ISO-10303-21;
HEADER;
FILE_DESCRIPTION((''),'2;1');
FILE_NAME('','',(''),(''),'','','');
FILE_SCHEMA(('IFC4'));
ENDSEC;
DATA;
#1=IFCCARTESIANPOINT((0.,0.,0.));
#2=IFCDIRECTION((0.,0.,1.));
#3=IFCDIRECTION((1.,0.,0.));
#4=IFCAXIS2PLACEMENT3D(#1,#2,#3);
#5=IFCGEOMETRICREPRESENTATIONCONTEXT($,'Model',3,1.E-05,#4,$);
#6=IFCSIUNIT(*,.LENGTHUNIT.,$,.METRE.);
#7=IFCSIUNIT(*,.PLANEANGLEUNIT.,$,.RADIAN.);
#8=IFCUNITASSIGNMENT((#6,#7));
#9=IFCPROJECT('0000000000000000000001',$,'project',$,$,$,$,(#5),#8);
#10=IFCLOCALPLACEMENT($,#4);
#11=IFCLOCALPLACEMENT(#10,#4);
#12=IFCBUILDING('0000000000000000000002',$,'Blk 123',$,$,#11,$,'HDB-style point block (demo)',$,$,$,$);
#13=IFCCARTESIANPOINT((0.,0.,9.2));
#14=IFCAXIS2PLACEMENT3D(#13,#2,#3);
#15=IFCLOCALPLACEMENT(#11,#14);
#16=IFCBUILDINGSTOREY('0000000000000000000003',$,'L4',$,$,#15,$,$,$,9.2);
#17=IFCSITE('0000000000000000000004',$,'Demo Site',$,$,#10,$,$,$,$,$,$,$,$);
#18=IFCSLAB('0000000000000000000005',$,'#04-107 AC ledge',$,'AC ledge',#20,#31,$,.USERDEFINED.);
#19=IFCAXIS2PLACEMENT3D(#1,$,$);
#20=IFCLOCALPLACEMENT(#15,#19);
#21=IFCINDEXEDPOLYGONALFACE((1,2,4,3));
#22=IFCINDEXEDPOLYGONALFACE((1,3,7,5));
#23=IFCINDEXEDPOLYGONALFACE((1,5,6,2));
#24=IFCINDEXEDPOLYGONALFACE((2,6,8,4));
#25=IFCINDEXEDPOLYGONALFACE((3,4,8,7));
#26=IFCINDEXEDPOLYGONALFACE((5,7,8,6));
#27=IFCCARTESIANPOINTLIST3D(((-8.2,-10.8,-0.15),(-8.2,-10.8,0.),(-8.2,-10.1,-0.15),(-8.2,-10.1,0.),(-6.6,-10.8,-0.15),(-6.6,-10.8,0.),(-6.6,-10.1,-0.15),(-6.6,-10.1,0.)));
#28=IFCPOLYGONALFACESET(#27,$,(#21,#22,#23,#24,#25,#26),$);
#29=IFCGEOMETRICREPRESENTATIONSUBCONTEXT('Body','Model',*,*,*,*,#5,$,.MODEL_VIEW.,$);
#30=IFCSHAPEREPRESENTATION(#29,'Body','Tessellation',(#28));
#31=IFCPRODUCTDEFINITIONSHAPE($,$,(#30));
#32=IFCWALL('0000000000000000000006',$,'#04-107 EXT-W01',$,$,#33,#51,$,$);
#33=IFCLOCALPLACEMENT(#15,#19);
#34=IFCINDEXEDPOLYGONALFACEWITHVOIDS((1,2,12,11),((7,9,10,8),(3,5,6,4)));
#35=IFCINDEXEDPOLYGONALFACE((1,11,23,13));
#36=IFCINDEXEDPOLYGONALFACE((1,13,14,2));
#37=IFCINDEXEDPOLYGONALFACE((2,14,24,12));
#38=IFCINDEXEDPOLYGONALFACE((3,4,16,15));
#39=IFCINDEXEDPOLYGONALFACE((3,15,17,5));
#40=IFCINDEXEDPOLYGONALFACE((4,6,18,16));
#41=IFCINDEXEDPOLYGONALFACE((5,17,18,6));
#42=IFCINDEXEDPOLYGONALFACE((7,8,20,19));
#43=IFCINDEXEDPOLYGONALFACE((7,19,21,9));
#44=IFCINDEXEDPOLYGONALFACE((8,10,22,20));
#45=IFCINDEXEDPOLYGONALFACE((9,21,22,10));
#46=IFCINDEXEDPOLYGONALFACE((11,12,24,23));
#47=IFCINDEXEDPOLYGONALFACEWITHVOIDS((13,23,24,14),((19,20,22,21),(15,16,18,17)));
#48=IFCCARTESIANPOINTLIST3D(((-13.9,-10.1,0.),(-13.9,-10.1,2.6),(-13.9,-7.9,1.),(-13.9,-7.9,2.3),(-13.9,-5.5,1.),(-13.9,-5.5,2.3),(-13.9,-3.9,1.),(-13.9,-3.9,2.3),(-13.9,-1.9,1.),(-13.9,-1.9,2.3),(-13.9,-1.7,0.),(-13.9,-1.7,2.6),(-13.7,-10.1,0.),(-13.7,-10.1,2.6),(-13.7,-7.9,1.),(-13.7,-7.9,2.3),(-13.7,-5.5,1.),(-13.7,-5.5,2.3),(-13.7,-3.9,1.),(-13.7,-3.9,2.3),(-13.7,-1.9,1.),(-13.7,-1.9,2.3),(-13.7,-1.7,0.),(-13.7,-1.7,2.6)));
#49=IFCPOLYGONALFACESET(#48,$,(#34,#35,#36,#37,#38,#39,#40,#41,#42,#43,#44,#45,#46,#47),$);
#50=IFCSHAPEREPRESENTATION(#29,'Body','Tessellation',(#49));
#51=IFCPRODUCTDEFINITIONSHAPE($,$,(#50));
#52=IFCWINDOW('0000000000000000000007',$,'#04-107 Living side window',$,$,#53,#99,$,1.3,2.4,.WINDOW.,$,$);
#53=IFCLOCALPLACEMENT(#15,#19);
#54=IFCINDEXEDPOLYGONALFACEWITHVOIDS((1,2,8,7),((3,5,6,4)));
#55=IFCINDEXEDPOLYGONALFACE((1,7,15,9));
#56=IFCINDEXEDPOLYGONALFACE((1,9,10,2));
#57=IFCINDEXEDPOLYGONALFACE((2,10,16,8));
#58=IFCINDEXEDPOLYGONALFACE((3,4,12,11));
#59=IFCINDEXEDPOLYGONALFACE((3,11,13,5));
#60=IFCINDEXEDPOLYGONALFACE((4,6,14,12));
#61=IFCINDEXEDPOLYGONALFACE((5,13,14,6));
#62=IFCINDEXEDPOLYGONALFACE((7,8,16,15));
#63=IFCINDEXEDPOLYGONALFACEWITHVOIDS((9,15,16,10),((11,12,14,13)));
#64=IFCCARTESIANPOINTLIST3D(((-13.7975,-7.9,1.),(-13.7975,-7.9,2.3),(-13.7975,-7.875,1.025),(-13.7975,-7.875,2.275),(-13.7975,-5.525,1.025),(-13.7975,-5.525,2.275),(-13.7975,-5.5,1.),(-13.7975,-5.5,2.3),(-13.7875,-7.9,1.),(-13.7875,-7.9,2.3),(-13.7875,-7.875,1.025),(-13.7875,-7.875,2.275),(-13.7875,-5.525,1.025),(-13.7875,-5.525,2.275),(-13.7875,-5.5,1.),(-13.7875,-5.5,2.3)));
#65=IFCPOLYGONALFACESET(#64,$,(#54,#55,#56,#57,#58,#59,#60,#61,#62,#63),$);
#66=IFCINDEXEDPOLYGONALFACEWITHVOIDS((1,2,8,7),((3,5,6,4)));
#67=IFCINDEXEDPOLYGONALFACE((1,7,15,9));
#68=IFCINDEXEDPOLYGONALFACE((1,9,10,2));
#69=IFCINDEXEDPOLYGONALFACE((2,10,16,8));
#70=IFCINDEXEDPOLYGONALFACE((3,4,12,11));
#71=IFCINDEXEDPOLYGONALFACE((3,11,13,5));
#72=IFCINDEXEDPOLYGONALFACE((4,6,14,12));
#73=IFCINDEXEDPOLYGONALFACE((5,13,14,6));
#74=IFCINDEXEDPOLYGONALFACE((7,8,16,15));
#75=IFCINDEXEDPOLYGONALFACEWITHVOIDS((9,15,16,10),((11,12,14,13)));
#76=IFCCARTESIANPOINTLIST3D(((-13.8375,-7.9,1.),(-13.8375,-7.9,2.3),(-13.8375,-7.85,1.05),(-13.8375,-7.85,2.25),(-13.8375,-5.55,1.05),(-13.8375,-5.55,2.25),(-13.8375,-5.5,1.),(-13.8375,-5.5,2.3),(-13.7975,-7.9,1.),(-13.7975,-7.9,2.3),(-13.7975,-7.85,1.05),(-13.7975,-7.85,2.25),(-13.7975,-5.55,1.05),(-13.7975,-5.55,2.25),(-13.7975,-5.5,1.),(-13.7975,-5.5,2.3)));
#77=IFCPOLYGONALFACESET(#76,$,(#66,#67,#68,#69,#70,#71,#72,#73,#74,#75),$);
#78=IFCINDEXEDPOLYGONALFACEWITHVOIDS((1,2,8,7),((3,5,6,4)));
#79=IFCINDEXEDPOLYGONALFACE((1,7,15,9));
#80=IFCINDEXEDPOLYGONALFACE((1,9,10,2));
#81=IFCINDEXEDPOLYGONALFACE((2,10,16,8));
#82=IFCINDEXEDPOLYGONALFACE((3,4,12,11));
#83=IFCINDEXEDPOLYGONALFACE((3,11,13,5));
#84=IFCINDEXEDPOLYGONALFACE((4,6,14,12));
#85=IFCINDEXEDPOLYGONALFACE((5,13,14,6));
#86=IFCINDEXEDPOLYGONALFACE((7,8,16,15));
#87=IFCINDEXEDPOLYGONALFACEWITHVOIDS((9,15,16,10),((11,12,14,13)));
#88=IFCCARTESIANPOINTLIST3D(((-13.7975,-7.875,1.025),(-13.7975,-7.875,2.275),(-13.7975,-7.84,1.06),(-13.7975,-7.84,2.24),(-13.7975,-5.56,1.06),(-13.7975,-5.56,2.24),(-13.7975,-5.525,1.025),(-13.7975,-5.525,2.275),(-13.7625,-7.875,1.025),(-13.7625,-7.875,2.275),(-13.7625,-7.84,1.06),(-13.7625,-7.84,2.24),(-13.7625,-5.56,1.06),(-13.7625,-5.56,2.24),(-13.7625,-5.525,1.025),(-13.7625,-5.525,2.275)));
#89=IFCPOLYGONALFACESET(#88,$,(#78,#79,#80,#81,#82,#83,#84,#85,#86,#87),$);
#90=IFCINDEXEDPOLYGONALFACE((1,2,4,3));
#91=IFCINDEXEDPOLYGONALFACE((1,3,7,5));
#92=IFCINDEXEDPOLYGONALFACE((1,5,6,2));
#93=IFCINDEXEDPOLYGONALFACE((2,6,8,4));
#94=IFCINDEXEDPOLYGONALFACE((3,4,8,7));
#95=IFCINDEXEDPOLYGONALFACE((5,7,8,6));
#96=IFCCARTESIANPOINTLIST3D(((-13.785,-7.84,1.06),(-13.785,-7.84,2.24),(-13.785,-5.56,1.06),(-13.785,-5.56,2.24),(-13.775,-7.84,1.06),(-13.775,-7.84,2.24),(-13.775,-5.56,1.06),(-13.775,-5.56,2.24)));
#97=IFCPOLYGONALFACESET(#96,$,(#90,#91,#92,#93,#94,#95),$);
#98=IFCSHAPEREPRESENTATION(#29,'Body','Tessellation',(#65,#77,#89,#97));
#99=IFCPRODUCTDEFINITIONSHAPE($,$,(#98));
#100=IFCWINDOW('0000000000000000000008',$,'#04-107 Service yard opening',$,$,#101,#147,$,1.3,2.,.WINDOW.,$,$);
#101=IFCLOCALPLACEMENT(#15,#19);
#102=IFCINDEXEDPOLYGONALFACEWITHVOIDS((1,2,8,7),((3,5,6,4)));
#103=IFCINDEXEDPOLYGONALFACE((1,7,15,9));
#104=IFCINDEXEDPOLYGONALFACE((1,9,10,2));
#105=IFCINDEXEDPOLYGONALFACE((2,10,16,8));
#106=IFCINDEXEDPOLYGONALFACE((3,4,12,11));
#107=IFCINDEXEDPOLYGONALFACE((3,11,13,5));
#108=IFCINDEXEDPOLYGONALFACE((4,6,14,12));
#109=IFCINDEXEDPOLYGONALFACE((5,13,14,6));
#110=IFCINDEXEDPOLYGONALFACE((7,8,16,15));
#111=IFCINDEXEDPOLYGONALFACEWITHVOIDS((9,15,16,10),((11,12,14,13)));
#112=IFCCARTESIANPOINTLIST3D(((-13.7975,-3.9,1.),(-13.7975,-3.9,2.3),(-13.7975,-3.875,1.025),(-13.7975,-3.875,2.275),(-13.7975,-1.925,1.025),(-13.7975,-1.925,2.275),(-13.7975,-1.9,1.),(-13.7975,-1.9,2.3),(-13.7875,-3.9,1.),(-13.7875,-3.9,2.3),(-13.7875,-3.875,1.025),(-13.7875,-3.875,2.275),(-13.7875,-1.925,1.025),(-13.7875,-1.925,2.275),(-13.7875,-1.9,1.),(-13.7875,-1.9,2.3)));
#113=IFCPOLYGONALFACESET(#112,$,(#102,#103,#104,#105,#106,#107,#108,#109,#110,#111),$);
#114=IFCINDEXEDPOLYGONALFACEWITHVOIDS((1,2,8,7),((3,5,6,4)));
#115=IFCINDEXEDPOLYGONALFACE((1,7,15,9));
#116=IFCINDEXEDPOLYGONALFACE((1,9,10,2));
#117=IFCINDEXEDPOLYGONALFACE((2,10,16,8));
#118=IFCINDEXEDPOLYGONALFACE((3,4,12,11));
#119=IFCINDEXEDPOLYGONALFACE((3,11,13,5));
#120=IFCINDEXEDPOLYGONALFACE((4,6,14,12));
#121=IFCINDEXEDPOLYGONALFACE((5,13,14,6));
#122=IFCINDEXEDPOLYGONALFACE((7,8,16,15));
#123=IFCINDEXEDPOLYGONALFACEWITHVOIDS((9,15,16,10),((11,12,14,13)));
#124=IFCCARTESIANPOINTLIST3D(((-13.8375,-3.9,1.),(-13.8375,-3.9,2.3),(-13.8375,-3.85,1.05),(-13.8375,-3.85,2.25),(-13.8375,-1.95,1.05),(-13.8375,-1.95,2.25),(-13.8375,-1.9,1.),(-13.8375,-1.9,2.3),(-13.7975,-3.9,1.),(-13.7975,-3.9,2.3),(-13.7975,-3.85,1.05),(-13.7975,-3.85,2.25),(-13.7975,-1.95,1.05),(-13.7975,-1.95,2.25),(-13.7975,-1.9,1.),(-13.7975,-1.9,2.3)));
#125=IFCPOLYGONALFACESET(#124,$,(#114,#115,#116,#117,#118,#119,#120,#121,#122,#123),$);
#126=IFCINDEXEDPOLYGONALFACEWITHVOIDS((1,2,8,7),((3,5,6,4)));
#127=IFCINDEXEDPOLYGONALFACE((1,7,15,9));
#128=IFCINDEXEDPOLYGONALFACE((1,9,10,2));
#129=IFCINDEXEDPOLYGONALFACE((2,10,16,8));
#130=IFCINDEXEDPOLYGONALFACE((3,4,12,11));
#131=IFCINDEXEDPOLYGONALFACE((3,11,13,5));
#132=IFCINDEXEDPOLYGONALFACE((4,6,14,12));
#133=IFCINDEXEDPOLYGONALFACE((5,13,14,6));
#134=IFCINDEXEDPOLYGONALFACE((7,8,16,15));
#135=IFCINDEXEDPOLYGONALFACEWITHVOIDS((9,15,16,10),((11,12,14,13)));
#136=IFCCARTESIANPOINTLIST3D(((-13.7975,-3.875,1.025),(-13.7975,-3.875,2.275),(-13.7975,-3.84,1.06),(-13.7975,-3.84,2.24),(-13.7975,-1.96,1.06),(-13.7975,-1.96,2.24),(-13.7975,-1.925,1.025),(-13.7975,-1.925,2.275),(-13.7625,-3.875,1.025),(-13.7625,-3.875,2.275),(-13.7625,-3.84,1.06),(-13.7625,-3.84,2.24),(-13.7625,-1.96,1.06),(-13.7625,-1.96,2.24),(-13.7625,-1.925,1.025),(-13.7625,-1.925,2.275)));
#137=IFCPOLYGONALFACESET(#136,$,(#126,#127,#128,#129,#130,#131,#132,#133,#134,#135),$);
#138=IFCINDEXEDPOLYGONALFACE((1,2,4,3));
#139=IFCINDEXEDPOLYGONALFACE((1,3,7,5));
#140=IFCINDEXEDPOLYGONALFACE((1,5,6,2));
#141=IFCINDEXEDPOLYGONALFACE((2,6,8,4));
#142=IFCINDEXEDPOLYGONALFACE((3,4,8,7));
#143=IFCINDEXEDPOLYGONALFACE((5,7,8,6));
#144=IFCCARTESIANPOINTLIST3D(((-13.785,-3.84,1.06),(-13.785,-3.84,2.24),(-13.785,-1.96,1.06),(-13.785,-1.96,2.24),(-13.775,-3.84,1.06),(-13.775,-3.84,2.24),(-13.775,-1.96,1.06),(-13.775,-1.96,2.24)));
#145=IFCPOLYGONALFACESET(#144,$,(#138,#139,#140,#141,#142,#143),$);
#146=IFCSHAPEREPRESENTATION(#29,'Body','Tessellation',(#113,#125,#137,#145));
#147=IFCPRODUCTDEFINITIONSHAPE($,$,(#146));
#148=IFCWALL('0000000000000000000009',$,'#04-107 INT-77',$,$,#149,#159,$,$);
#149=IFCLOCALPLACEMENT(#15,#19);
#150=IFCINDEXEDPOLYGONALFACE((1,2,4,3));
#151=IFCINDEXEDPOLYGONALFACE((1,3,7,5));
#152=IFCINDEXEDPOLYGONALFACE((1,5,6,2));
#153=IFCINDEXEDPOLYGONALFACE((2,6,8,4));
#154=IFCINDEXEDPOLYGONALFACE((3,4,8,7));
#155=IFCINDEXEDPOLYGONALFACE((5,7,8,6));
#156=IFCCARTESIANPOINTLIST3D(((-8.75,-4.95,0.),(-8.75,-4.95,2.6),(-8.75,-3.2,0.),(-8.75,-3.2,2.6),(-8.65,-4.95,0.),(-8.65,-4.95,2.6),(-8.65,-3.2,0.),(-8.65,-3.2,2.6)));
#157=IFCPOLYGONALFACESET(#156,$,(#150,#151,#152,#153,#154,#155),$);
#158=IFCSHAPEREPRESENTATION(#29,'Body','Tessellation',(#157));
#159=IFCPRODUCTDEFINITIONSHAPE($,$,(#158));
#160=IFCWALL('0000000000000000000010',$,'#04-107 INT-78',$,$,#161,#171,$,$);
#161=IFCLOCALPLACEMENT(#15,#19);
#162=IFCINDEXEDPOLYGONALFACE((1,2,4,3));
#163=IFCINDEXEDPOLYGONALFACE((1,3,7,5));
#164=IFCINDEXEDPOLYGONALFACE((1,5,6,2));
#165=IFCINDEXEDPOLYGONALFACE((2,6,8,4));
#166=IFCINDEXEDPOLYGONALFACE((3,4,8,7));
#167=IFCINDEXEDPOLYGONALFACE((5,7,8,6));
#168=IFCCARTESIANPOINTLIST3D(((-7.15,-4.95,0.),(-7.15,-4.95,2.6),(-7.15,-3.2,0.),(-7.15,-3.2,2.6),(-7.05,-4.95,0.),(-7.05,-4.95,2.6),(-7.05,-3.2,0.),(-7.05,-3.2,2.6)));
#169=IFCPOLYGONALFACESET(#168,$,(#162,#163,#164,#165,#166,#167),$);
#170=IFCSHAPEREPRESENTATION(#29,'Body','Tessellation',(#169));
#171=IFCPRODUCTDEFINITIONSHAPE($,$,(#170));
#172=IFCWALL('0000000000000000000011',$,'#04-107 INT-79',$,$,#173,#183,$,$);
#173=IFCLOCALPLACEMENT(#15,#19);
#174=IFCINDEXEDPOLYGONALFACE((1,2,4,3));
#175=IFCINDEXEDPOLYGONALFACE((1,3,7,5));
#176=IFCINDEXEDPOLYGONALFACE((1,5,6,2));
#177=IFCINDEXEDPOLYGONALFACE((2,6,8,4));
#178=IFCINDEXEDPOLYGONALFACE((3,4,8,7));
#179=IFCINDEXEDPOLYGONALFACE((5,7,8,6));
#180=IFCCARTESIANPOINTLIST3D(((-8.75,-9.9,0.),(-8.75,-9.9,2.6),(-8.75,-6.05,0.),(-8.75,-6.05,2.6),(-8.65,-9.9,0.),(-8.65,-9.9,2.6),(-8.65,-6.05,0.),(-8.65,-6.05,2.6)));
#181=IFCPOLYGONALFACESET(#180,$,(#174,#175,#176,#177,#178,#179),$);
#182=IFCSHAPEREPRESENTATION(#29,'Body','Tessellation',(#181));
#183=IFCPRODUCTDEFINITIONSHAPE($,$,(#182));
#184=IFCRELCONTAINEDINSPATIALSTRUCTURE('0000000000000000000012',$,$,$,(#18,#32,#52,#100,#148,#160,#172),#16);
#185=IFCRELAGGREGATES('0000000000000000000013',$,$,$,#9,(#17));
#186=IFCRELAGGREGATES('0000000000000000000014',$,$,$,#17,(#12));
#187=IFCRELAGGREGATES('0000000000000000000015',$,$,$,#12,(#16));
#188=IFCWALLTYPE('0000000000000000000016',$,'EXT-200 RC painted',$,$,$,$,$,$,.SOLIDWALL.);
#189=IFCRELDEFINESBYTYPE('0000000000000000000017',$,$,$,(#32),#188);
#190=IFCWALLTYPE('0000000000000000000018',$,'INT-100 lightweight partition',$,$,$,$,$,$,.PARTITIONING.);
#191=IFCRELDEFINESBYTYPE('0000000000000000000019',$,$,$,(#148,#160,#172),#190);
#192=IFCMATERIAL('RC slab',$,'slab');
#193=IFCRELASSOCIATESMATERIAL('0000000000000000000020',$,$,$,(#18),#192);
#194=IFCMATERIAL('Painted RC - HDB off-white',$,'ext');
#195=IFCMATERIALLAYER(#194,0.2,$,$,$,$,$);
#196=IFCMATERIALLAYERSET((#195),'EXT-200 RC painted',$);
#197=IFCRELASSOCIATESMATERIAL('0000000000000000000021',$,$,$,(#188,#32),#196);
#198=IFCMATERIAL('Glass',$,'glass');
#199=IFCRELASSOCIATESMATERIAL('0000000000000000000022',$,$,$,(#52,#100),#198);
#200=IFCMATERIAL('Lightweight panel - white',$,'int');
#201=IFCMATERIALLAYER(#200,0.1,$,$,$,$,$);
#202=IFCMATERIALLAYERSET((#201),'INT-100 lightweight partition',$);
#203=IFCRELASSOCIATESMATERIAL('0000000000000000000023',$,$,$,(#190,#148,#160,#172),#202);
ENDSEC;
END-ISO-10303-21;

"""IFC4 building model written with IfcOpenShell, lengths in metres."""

from ifc_helpers import new_model, si_unit, frame, origin, origin_with_axes, place, context, subcontext, project, spatial, polyline, line, indexed_curve, outline, extrude, material, layer, layer_set, layer_usage, type_object, element, fill, save


model = new_model("IFC4")

# Units and contexts
model_context = context("Model", 3, precision=1e-05, world=origin_with_axes())
body_context = subcontext(model_context, "Body", "Model", "MODEL_VIEW")
ifc_project = project(units=[si_unit("LENGTHUNIT", "METRE"), si_unit("PLANEANGLEUNIT", "RADIAN")], contexts=[model_context])

# Site, building, storey
site_placement = place(None, origin_with_axes())
site = spatial("IfcSite", under=ifc_project, at=site_placement, Name="Demo Site")
building_placement = place(site_placement, origin_with_axes())
building = spatial("IfcBuilding", under=site, at=building_placement, Name="Blk 123", LongName="HDB-style point block (demo)")
storey_placement = place(building_placement, frame((0.0, 0.0, 9.2), z_axis=(0.0, 0.0, 1.0), x_axis=(1.0, 0.0, 0.0)))
storey = spatial("IfcBuildingStorey", under=building, at=storey_placement, Name="L4", Elevation=9.2)

# Slab
ifc_material_1 = material(Name="RC slab", Category="slab")
slab_placement = place(storey_placement, frame((-7.4, -10.45, -0.15), z_axis=(0.0, 0.0, 1.0), x_axis=(1.0, 0.0, 0.0)))
element("IfcSlab", 1, at=slab_placement, inside=storey, material=ifc_material_1, Name="#04-107 AC ledge", ObjectType="AC ledge", PredefinedType="USERDEFINED", context=body_context, shape_type="SweptSolid", body=[
    extrude(outline(polyline([(-0.8, 0.35), (-0.8, -0.35), (0.8, -0.35), (0.8, 0.35), (-0.8, 0.35)])), origin(), (0.0, 0.0, 1.0), 0.15),
])

# Wall, openings, windows
ifc_material_2 = material(Name="Painted RC - HDB off-white", Category="ext")
ifc_layer_1 = layer(ifc_material_2, 0.2)
ifc_layer_set_1 = layer_set([ifc_layer_1], Name="EXT-200 RC painted")
ifc_layer_usage_1 = layer_usage(ifc_layer_set_1, "AXIS2", "POSITIVE", 0.0)
wall_type_1 = type_object("IfcWallType", Name="EXT-200 RC painted", PredefinedType="SOLIDWALL", material=ifc_layer_set_1)
wall_1_placement = place(storey_placement, frame((-13.9, -1.7, 0.0), z_axis=(0.0, 0.0, 1.0), x_axis=(0.0, -1.0, 0.0)))
wall_1 = element("IfcWall", 2, at=wall_1_placement, inside=storey, type_object=wall_type_1, material=ifc_layer_usage_1, Name="#04-107 EXT-W01", context=body_context, shape_type="SweptSolid", body=[
    extrude(outline(indexed_curve([(0.0, 0.0), (0.0, 0.2), (8.4, 0.2), (8.4, 0.0), (0.0, 0.0)], self_intersect=False)), origin_with_axes(), (0.0, 0.0, 1.0), 2.6),
])
opening_1_placement = place(wall_1_placement, frame((3.8, -0.1, 1.0), z_axis=(0.0, 0.0, 1.0), x_axis=(1.0, 0.0, 0.0)))
opening_1 = element("IfcOpeningElement", 3, at=opening_1_placement, cuts=wall_1, context=body_context, shape_type="SweptSolid", body=[
    extrude(outline(indexed_curve([(0.0, 0.0), (0.0, 0.4), (2.4, 0.4), (2.4, 0.0), (0.0, 0.0)], self_intersect=False)), origin_with_axes(), (0.0, 0.0, 1.0), 1.3),
])
opening_2_placement = place(wall_1_placement, frame((0.2, -0.1, 1.0), z_axis=(0.0, 0.0, 1.0), x_axis=(1.0, 0.0, 0.0)))
opening_2 = element("IfcOpeningElement", 4, at=opening_2_placement, cuts=wall_1, context=body_context, shape_type="SweptSolid", body=[
    extrude(outline(indexed_curve([(0.0, 0.0), (0.0, 0.4), (2.0, 0.4), (2.0, 0.0), (0.0, 0.0)], self_intersect=False)), origin_with_axes(), (0.0, 0.0, 1.0), 1.3),
])
ifc_material_3 = material(Name="Glass", Category="glass")
window_1_placement = place(opening_1_placement, frame((0.0, 0.1125, 0.0), z_axis=(0.0, 0.0, 1.0), x_axis=(1.0, 0.0, 0.0)))
window_1 = element("IfcWindow", 5, at=window_1_placement, inside=storey, material=ifc_material_3, Name="#04-107 Living side window", OverallHeight=1.3, OverallWidth=2.4, PredefinedType="WINDOW", context=body_context, shape_type="SweptSolid", body=[
    extrude(outline(indexed_curve([(0.0, 0.0), (2.4, 0.0), (2.4, 1.3), (0.0, 1.3)], segments=[line(1, 2, 3, 4, 1)]), holes=[indexed_curve([(0.025, 0.025), (2.375, 0.025), (2.375, 1.275), (0.025, 1.275)], segments=[line(1, 2, 3, 4, 1)])]), frame((0.0, 0.09, 0.0), z_axis=(0.0, -1.0, 0.0), x_axis=(1.0, 0.0, 0.0)), (0.0, 0.0, -1.0), 0.01),
    extrude(outline(indexed_curve([(0.0, 0.0), (2.4, 0.0), (2.4, 1.3), (0.0, 1.3)], segments=[line(1, 2, 3, 4, 1)]), holes=[indexed_curve([(0.05, 0.05), (2.35, 0.05), (2.35, 1.25), (0.05, 1.25)], segments=[line(1, 2, 3, 4, 1)])]), frame((0.0, 0.05, 0.0), z_axis=(0.0, -1.0, 0.0), x_axis=(1.0, 0.0, 0.0)), (0.0, 0.0, -1.0), 0.04),
    extrude(outline(indexed_curve([(0.0, 0.0), (2.35, 0.0), (2.35, 1.25), (0.0, 1.25)], segments=[line(1, 2, 3, 4, 1)]), holes=[indexed_curve([(0.035, 0.035), (2.315, 0.035), (2.315, 1.215), (0.035, 1.215)], segments=[line(1, 2, 3, 4, 1)])]), frame((0.025, 0.09, 0.025), z_axis=(0.0, -1.0, 0.0), x_axis=(1.0, 0.0, 0.0)), (0.0, 0.0, -1.0), 0.035),
    extrude(outline(indexed_curve([(0.035, 0.035), (2.315, 0.035), (2.315, 1.215), (0.035, 1.215)], segments=[line(1, 2, 3, 4, 1)])), frame((0.025, 0.1025, 0.025), z_axis=(0.0, -1.0, 0.0), x_axis=(1.0, 0.0, 0.0)), (0.0, 0.0, -1.0), 0.01),
])
fill(opening_1, window_1)
window_2_placement = place(opening_2_placement, frame((0.0, 0.1125, 0.0), z_axis=(0.0, 0.0, 1.0), x_axis=(1.0, 0.0, 0.0)))
window_2 = element("IfcWindow", 6, at=window_2_placement, inside=storey, material=ifc_material_3, Name="#04-107 Service yard opening", OverallHeight=1.3, OverallWidth=2.0, PredefinedType="WINDOW", context=body_context, shape_type="SweptSolid", body=[
    extrude(outline(indexed_curve([(0.0, 0.0), (2.0, 0.0), (2.0, 1.3), (0.0, 1.3)], segments=[line(1, 2, 3, 4, 1)]), holes=[indexed_curve([(0.025, 0.025), (1.975, 0.025), (1.975, 1.275), (0.025, 1.275)], segments=[line(1, 2, 3, 4, 1)])]), frame((0.0, 0.09, 0.0), z_axis=(0.0, -1.0, 0.0), x_axis=(1.0, 0.0, 0.0)), (0.0, 0.0, -1.0), 0.01),
    extrude(outline(indexed_curve([(0.0, 0.0), (2.0, 0.0), (2.0, 1.3), (0.0, 1.3)], segments=[line(1, 2, 3, 4, 1)]), holes=[indexed_curve([(0.05, 0.05), (1.95, 0.05), (1.95, 1.25), (0.05, 1.25)], segments=[line(1, 2, 3, 4, 1)])]), frame((0.0, 0.05, 0.0), z_axis=(0.0, -1.0, 0.0), x_axis=(1.0, 0.0, 0.0)), (0.0, 0.0, -1.0), 0.04),
    extrude(outline(indexed_curve([(0.0, 0.0), (1.95, 0.0), (1.95, 1.25), (0.0, 1.25)], segments=[line(1, 2, 3, 4, 1)]), holes=[indexed_curve([(0.035, 0.035), (1.915, 0.035), (1.915, 1.215), (0.035, 1.215)], segments=[line(1, 2, 3, 4, 1)])]), frame((0.025, 0.09, 0.025), z_axis=(0.0, -1.0, 0.0), x_axis=(1.0, 0.0, 0.0)), (0.0, 0.0, -1.0), 0.035),
    extrude(outline(indexed_curve([(0.035, 0.035), (1.915, 0.035), (1.915, 1.215), (0.035, 1.215)], segments=[line(1, 2, 3, 4, 1)])), frame((0.025, 0.1025, 0.025), z_axis=(0.0, -1.0, 0.0), x_axis=(1.0, 0.0, 0.0)), (0.0, 0.0, -1.0), 0.01),
])
fill(opening_2, window_2)

# Walls
ifc_material_4 = material(Name="Lightweight panel - white", Category="int")
ifc_layer_2 = layer(ifc_material_4, 0.1)
ifc_layer_set_2 = layer_set([ifc_layer_2], Name="INT-100 lightweight partition")
ifc_layer_usage_2 = layer_usage(ifc_layer_set_2, "AXIS2", "POSITIVE", -0.05)
wall_type_2 = type_object("IfcWallType", Name="INT-100 lightweight partition", PredefinedType="PARTITIONING", material=ifc_layer_set_2)
for number, where, z_axis, x_axis, name in (
    (7, (-8.7, -3.2, 0.0), (0.0, 0.0, 1.0), (0.0, -1.0, 0.0), "#04-107 INT-77"),
    (8, (-7.1, -3.2, 0.0), (0.0, 0.0, 1.0), (0.0, -1.0, 0.0), "#04-107 INT-78"),
):
    element("IfcWall", number, at=place(storey_placement, frame(where, z_axis=z_axis, x_axis=x_axis)), inside=storey, type_object=wall_type_2, material=ifc_layer_usage_2, Name=name, context=body_context, shape_type="SweptSolid", body=[
        extrude(outline(indexed_curve([(0.0, 0.0), (0.0, 0.1), (1.75, 0.1), (1.75, 0.0), (0.0, 0.0)], self_intersect=False)), frame((0.0, -0.05, 0.0), z_axis=(0.0, 0.0, 1.0), x_axis=(1.0, 0.0, 0.0)), (0.0, 0.0, 1.0), 2.6),
    ])
wall_2_placement = place(storey_placement, frame((-8.7, -6.05, 0.0), z_axis=(0.0, 0.0, 1.0), x_axis=(0.0, -1.0, 0.0)))
element("IfcWall", 9, at=wall_2_placement, inside=storey, type_object=wall_type_2, material=ifc_layer_usage_2, Name="#04-107 INT-79", context=body_context, shape_type="SweptSolid", body=[
    extrude(outline(indexed_curve([(0.0, 0.0), (0.0, 0.1), (3.85, 0.1), (3.85, 0.0), (0.0, 0.0)], self_intersect=False)), frame((0.0, -0.05, 0.0), z_axis=(0.0, 0.0, 1.0), x_axis=(1.0, 0.0, 0.0)), (0.0, 0.0, 1.0), 2.6),
])

save(model, "model.ifc")
